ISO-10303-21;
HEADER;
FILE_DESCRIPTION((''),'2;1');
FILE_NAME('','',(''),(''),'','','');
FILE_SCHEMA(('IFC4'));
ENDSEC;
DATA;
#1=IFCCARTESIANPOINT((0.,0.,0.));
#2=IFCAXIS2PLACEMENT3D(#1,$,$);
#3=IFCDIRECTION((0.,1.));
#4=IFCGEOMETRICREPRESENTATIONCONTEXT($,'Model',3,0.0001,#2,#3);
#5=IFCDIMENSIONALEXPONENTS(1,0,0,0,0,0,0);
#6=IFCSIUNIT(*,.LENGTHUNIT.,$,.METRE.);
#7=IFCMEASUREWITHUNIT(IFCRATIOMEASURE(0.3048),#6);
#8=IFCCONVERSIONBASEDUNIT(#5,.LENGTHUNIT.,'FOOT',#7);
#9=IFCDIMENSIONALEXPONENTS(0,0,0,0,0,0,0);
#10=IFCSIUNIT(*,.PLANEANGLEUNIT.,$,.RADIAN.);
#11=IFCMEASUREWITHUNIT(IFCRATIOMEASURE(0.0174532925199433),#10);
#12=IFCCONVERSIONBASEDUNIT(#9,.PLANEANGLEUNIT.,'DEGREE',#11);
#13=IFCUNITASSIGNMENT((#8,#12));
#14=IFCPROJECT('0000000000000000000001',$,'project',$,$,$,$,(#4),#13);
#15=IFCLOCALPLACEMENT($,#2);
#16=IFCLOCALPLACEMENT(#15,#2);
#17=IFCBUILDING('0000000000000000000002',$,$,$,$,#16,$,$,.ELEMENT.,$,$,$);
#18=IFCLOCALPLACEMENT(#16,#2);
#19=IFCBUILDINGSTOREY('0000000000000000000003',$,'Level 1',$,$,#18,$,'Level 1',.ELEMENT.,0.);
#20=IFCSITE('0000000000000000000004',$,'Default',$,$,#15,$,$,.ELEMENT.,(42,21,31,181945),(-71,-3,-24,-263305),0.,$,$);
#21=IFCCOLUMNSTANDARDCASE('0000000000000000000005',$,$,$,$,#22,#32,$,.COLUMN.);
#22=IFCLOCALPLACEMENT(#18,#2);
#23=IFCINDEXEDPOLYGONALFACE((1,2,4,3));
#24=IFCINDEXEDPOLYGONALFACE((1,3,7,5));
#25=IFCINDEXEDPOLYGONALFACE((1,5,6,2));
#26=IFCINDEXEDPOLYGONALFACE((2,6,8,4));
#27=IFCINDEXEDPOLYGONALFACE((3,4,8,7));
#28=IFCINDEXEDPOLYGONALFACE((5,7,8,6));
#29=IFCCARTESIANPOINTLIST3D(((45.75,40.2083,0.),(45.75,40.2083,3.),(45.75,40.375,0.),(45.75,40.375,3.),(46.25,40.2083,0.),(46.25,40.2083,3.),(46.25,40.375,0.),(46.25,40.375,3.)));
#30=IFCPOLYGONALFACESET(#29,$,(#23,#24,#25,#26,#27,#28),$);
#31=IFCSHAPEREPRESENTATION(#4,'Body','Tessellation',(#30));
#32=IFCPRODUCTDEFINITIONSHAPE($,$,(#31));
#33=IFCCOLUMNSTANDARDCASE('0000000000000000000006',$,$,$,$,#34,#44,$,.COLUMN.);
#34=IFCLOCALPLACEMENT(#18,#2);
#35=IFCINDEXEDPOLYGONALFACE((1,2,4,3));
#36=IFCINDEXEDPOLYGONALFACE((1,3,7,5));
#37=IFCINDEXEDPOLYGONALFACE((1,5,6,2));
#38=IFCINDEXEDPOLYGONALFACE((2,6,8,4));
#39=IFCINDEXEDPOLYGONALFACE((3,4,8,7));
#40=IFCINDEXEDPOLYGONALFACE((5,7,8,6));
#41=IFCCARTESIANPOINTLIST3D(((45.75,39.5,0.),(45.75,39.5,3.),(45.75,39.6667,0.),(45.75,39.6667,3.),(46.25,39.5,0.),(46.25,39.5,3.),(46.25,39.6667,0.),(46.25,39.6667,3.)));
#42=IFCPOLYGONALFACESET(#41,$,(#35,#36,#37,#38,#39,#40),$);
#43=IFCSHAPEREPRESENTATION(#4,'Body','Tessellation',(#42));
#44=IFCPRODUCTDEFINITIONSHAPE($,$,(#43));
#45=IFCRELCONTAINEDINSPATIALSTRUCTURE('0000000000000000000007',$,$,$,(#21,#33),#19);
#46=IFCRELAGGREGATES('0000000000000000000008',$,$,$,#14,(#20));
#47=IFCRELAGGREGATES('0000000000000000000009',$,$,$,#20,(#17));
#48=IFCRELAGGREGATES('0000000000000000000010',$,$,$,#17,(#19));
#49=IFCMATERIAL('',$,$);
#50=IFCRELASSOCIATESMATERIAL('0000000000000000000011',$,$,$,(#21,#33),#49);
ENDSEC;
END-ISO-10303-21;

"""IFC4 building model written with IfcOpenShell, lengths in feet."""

from ifc_helpers import new_model, entity, si_unit, converted_unit, direction, frame, origin, place, context, project, spatial, rectangle, extrude, material, element, save


model = new_model("IFC4")

# Units and contexts
model_context = context("Model", 3, precision=0.0001, world=origin(), true_north=direction((0.0, 1.0)))
ifc_project = project(units=[converted_unit("LENGTHUNIT", "FOOT", entity("IfcRatioMeasure", 0.3048), si_unit("LENGTHUNIT", "METRE"), dimensions=[1, 0, 0, 0, 0, 0, 0]), converted_unit("PLANEANGLEUNIT", "DEGREE", entity("IfcRatioMeasure", 0.0174532925199433), si_unit("PLANEANGLEUNIT", "RADIAN"), dimensions=[0, 0, 0, 0, 0, 0, 0])], contexts=[model_context])

# Site, building, storey
site_placement = place(None, origin())
site = spatial("IfcSite", under=ifc_project, at=site_placement, Name="Default", CompositionType="ELEMENT", RefLatitude=(42, 21, 31, 181945), RefLongitude=(-71, -3, -24, -263305), RefElevation=0.0)
building_placement = place(site_placement, origin())
building = spatial("IfcBuilding", under=site, at=building_placement, CompositionType="ELEMENT")
storey_placement = place(building_placement, origin())
storey = spatial("IfcBuildingStorey", under=building, at=storey_placement, Name="Level 1", LongName="Level 1", CompositionType="ELEMENT", Elevation=0.0)

# Columns
placement_1 = place(storey_placement, frame((46.0, 46.25, 0.0), z_axis=(0.0, 0.0, 1.0), x_axis=(0.0, -1.0, 0.0)))
ifc_material_1 = material(Name="")
for number, where, z_axis, x_axis in (
    (1, (5.9583, 0.0, 0.0), (0.0, 0.0, 1.0), (1.0, 0.0, 0.0)),
    (2, (6.6667, 0.0, 0.0), (0.0, 0.0, 1.0), (1.0, 0.0, 0.0)),
):
    element("IfcColumnStandardCase", number, at=place(placement_1, frame(where, z_axis=z_axis, x_axis=x_axis)), inside=storey, material=ifc_material_1, PredefinedType="COLUMN", context=model_context, shape_type="SweptSolid", body=[
        extrude(rectangle(XDim=0.1667, YDim=0.5), origin(), (0.0, 0.0, 1.0), 3.0),
    ])

save(model, "model.ifc")
